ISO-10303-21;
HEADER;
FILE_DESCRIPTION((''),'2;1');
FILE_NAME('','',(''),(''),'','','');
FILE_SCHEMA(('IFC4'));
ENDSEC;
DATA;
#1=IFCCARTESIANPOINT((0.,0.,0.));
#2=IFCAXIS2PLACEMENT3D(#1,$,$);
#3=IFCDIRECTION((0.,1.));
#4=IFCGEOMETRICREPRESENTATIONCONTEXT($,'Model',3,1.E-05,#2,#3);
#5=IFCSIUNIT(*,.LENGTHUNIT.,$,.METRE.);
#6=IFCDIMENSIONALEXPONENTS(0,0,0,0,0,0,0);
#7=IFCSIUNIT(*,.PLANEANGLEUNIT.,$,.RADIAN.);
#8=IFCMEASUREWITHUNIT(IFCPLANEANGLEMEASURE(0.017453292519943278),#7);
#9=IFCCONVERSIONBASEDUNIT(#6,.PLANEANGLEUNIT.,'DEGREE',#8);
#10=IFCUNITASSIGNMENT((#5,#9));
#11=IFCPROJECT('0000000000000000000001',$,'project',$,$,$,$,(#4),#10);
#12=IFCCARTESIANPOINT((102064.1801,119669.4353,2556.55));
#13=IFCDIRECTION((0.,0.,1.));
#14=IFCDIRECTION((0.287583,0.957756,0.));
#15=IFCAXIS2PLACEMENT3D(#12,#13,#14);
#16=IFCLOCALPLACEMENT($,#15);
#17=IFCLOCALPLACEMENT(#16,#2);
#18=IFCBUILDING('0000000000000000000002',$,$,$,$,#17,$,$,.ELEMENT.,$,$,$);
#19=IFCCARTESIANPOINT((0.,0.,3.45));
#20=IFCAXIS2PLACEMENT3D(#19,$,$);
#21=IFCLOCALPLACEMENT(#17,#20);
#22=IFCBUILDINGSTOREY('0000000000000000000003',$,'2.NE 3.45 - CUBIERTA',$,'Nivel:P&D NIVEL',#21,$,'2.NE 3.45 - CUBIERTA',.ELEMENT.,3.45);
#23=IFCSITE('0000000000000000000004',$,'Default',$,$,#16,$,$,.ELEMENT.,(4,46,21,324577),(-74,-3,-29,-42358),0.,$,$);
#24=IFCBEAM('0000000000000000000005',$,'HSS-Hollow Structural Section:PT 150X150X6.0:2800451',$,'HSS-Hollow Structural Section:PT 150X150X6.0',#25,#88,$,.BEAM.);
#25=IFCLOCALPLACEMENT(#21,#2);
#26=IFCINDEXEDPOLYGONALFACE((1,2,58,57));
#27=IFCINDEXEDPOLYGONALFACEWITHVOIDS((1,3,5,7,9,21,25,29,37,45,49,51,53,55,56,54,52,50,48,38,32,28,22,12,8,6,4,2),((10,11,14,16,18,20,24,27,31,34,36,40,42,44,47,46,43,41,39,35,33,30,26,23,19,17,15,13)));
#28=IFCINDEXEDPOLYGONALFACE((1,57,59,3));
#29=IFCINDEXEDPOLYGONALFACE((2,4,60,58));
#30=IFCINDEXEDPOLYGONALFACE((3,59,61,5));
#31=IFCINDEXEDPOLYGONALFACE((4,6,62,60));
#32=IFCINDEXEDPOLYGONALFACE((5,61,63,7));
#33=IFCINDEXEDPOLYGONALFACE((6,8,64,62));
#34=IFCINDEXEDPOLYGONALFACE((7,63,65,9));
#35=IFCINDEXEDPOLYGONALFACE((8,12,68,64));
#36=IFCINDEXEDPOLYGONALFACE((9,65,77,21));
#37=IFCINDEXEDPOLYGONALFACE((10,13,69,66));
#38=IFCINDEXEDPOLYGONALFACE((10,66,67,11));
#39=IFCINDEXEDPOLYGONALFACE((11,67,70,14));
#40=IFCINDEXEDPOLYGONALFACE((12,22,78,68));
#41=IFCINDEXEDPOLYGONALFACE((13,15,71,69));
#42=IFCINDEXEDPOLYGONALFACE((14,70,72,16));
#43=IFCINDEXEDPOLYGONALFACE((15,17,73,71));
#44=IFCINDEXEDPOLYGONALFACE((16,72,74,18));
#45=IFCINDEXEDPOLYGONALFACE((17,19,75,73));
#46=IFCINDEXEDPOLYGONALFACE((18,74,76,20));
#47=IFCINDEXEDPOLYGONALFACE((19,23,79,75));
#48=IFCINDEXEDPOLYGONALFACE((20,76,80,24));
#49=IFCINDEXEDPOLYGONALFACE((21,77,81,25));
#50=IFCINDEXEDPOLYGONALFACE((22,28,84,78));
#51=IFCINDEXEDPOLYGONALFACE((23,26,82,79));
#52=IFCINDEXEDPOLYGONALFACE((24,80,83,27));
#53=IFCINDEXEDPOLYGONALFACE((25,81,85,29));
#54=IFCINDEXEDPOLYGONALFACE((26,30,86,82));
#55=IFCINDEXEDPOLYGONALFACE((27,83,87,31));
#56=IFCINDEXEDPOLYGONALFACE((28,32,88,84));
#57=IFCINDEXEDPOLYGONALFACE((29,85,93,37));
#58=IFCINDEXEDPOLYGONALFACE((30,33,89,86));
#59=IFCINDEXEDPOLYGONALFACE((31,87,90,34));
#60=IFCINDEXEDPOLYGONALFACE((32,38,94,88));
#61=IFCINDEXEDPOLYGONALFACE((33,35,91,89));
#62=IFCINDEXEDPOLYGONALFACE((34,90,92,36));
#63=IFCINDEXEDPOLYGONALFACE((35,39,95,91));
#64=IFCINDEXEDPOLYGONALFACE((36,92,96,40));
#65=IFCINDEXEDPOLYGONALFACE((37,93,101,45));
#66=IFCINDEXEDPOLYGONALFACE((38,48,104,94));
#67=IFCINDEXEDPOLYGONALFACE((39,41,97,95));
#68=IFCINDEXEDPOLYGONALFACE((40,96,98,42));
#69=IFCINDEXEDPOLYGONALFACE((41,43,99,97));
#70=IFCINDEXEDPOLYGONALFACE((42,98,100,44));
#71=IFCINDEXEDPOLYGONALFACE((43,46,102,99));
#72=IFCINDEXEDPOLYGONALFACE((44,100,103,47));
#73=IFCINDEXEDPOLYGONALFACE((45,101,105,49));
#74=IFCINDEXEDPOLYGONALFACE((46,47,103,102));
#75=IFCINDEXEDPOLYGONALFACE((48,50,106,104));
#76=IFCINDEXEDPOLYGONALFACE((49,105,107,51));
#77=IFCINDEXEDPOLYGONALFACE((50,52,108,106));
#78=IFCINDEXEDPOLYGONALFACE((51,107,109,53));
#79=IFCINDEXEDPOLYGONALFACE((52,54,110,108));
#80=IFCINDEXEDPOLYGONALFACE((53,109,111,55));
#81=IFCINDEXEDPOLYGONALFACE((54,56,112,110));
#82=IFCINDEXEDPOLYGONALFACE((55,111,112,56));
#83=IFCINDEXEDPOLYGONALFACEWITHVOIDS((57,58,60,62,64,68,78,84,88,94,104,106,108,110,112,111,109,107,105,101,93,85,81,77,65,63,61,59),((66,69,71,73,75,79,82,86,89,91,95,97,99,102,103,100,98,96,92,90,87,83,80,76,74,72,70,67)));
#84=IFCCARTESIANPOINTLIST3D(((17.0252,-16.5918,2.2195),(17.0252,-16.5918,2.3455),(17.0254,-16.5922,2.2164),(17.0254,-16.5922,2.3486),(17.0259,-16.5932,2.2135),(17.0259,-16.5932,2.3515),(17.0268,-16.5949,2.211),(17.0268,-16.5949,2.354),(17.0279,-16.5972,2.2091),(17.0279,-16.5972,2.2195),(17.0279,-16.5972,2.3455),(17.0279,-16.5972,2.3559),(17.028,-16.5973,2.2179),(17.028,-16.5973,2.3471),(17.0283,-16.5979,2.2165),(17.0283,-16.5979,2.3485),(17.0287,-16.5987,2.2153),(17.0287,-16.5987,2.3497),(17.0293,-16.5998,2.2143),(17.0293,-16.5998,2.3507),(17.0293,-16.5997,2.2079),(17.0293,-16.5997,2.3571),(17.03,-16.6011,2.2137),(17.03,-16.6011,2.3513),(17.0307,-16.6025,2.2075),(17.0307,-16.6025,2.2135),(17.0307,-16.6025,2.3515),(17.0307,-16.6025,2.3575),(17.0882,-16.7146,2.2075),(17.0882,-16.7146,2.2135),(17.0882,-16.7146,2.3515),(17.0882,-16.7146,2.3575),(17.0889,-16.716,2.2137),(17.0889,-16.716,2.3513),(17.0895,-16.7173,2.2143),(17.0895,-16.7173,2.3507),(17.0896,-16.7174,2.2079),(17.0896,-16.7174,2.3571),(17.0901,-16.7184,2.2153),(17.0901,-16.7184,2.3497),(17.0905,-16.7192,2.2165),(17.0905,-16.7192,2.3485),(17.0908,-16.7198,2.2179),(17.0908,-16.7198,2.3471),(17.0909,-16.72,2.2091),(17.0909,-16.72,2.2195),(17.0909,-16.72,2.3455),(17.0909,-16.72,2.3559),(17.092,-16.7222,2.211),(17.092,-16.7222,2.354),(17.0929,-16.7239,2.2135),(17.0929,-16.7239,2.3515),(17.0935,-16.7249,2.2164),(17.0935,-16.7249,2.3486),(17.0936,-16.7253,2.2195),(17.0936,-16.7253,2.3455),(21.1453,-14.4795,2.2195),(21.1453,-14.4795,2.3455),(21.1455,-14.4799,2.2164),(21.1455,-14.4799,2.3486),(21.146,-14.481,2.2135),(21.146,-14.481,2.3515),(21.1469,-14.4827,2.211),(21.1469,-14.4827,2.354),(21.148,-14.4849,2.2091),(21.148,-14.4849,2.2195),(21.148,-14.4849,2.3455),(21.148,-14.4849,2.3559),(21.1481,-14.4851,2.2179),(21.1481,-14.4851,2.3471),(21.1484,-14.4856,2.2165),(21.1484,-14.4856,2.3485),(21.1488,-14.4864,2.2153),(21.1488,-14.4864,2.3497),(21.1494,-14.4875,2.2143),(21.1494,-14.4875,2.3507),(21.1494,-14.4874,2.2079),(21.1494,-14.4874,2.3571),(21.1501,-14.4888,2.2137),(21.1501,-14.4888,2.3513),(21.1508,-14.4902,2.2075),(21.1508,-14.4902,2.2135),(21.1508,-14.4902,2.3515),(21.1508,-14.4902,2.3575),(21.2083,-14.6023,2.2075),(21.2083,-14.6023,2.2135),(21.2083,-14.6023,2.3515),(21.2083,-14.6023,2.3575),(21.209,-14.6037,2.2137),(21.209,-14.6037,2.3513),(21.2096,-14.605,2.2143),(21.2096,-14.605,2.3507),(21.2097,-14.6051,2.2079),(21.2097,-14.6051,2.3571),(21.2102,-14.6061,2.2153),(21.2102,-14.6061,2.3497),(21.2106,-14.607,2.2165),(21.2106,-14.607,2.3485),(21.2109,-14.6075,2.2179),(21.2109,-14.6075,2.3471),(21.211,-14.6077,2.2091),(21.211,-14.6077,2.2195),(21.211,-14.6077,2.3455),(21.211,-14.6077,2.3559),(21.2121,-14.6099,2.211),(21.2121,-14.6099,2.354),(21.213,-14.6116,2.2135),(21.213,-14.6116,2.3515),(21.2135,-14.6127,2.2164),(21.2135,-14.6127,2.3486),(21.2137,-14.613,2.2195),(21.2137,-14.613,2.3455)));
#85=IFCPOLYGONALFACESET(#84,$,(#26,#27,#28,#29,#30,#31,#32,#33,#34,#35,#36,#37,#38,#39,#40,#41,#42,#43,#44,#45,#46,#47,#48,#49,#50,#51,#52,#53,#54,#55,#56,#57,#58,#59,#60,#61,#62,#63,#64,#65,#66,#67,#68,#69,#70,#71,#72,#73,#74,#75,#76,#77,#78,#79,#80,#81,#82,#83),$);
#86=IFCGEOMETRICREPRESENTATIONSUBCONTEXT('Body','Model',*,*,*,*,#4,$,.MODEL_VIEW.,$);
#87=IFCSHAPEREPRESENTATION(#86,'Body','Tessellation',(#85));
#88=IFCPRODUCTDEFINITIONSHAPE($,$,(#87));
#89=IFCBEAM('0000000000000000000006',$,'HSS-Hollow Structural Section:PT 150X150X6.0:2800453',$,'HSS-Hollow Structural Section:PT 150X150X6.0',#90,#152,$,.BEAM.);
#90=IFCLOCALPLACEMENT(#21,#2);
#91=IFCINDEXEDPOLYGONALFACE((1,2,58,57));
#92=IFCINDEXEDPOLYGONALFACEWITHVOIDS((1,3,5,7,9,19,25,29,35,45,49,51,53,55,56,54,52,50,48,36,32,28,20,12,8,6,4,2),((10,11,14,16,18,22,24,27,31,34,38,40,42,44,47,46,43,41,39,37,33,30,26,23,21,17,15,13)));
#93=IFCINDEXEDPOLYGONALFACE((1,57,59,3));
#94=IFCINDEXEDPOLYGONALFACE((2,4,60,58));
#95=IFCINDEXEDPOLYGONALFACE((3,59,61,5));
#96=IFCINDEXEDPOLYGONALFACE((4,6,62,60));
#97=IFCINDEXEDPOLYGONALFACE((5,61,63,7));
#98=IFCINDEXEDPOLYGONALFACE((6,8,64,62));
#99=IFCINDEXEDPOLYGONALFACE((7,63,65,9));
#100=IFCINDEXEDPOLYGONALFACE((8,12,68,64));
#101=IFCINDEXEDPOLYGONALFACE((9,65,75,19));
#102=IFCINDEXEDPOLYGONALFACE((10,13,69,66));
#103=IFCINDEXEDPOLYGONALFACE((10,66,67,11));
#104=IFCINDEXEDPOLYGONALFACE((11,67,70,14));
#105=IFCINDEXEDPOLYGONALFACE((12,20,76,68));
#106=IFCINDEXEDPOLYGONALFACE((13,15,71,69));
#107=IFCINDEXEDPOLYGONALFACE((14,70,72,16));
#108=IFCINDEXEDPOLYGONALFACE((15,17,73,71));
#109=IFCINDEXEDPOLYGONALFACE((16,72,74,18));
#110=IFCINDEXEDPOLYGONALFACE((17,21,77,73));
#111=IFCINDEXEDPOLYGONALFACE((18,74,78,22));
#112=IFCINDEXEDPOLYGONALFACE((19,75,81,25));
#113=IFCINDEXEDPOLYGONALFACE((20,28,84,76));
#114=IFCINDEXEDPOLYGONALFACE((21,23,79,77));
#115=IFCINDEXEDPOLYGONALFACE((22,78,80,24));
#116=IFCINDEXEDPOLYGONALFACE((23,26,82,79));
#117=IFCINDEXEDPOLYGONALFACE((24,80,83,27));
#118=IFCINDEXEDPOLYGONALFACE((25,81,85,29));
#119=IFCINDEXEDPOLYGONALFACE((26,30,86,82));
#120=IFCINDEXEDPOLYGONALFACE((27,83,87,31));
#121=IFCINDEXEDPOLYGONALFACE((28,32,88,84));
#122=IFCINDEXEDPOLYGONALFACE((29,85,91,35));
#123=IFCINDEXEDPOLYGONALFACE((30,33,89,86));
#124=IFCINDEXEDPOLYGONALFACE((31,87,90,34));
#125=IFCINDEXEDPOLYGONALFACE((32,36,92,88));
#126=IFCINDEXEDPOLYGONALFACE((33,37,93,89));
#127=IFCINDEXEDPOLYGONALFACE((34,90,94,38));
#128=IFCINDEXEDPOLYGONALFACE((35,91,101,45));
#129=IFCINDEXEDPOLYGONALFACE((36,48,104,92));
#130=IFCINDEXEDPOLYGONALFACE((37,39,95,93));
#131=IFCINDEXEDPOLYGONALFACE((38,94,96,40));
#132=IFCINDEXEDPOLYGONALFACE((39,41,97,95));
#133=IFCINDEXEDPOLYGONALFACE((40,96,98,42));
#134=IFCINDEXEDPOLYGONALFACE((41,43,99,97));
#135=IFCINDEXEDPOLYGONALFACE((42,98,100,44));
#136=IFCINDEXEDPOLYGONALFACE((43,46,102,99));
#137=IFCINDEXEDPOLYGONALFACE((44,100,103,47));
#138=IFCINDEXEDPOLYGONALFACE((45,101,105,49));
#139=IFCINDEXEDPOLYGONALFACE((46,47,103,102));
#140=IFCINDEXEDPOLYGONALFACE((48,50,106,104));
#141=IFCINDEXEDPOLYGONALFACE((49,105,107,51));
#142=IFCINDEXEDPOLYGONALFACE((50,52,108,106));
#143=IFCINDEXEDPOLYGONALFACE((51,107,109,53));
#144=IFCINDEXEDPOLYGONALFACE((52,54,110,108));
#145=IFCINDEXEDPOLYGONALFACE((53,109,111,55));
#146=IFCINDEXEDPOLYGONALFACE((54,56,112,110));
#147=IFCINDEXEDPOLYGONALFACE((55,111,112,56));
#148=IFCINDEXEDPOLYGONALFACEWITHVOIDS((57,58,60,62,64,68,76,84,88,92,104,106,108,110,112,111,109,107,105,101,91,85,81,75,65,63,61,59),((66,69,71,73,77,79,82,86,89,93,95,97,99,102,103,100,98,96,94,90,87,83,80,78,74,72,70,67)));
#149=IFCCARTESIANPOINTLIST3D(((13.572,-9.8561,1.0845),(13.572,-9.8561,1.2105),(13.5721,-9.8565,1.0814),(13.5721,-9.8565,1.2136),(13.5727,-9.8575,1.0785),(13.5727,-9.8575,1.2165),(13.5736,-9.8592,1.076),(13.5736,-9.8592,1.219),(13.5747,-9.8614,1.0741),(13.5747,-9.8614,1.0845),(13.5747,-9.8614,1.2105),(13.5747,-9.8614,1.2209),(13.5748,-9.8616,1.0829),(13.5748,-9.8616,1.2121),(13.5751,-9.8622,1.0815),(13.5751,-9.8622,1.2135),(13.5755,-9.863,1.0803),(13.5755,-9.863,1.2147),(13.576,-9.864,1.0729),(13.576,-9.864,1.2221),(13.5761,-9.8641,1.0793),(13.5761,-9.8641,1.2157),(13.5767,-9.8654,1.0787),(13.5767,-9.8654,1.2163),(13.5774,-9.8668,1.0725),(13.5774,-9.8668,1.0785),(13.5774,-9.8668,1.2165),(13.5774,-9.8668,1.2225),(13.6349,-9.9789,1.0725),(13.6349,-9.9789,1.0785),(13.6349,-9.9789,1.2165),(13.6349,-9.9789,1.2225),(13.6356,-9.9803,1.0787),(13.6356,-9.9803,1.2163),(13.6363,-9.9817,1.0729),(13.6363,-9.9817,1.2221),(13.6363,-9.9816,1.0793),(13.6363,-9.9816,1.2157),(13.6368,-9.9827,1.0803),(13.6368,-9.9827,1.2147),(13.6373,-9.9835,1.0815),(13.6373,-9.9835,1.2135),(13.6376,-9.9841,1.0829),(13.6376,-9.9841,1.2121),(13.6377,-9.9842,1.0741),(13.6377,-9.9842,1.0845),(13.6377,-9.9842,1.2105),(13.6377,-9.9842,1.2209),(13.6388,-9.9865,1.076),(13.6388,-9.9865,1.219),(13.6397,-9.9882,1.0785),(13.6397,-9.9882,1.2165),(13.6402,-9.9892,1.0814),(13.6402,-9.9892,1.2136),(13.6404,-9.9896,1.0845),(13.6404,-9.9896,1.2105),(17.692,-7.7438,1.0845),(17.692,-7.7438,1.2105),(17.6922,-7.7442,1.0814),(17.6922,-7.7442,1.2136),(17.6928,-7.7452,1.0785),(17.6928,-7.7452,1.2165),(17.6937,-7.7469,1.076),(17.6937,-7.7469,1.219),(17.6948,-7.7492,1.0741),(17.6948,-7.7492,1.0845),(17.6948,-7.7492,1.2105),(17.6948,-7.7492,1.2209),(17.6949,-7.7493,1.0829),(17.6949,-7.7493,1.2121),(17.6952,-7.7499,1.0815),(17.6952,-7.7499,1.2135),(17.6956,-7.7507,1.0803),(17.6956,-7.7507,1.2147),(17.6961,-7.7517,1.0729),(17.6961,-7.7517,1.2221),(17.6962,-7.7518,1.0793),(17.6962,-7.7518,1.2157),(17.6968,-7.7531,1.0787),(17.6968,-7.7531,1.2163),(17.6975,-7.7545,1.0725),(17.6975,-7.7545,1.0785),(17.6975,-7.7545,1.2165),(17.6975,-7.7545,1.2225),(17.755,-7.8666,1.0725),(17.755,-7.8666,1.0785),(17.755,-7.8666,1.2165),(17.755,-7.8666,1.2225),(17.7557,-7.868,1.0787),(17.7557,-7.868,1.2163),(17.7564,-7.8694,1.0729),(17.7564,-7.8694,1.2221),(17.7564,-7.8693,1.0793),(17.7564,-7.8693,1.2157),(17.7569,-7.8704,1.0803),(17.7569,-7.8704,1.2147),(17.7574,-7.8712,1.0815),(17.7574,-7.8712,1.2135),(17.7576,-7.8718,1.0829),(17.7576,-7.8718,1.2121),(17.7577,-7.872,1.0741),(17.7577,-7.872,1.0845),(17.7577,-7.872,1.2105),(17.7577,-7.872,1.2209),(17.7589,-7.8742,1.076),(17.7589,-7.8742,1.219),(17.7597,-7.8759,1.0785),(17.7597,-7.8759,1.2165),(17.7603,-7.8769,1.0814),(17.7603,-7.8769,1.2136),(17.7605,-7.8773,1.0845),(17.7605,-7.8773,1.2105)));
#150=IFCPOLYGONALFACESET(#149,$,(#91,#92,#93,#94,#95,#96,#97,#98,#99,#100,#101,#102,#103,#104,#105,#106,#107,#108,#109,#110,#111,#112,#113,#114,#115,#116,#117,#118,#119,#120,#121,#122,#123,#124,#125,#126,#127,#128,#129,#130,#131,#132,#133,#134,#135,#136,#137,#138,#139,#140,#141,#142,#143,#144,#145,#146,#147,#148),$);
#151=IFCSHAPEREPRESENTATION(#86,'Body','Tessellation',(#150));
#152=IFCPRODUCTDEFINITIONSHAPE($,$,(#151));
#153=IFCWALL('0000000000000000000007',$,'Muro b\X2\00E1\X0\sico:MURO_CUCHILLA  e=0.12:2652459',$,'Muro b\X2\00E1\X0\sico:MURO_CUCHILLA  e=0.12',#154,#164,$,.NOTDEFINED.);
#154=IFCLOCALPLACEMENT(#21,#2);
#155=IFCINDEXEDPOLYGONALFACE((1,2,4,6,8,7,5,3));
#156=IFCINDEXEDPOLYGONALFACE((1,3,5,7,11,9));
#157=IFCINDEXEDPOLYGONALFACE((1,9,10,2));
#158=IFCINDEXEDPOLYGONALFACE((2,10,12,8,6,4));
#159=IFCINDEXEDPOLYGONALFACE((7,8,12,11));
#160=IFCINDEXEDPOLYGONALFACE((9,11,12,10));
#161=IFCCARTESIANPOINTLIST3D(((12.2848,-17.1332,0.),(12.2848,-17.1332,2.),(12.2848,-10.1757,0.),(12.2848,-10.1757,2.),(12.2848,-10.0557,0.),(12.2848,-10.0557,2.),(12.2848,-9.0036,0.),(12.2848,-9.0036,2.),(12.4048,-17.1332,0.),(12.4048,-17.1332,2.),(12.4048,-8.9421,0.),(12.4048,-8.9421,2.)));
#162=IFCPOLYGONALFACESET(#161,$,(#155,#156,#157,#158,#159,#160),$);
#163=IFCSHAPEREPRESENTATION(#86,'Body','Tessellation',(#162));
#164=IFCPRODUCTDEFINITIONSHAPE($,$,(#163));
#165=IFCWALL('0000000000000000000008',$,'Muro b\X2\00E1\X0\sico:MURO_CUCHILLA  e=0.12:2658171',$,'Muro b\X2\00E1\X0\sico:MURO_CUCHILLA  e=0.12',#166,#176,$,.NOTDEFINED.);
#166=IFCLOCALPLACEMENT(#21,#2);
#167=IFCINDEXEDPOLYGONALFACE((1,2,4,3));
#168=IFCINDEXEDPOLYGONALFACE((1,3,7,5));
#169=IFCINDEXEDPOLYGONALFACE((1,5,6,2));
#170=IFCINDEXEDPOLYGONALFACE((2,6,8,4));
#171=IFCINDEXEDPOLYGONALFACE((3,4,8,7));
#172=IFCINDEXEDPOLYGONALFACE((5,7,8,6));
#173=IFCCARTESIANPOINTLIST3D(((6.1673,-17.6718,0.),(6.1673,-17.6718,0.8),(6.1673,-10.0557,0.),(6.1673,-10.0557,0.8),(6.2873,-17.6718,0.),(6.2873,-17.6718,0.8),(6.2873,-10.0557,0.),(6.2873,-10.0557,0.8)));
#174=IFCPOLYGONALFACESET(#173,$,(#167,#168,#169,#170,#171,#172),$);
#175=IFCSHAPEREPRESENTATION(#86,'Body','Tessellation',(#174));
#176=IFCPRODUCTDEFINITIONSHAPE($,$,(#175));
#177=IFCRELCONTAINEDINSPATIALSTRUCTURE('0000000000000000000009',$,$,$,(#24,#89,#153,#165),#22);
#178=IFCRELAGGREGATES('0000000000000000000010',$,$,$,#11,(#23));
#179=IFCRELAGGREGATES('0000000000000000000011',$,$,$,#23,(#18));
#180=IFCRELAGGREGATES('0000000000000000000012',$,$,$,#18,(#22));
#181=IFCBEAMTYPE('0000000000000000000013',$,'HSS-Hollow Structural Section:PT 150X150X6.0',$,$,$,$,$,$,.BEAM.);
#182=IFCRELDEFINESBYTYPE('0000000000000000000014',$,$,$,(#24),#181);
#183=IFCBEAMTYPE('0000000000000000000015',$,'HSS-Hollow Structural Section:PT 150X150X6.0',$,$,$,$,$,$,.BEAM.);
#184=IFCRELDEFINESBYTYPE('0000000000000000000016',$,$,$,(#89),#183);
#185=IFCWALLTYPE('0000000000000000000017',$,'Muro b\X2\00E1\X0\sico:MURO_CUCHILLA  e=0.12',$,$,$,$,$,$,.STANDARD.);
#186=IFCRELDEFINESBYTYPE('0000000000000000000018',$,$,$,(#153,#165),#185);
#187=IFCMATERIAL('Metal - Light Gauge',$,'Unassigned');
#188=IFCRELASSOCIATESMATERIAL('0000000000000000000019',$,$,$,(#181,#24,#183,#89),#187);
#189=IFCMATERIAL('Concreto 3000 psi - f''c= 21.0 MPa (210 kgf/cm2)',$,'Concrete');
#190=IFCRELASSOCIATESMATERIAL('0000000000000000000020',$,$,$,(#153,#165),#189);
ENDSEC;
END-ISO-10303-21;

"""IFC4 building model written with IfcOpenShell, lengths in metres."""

from ifc_helpers import new_model, entity, si_unit, converted_unit, direction, frame, origin, place, context, subcontext, project, spatial, line, arc, indexed_curve, outline, extrude, source, transform, mapped, material, type_object, type_shapes, element, save


model = new_model("IFC4")

# Units and contexts
model_context = context("Model", 3, precision=1e-05, world=origin(), true_north=direction((0.0, 1.0)))
body_context = subcontext(model_context, "Body", "Model", "MODEL_VIEW")
ifc_project = project(units=[si_unit("LENGTHUNIT", "METRE"), converted_unit("PLANEANGLEUNIT", "DEGREE", entity("IfcPlaneAngleMeasure", 0.017453292519943278), si_unit("PLANEANGLEUNIT", "RADIAN"), dimensions=[0, 0, 0, 0, 0, 0, 0])], contexts=[model_context])

# Site, building, storey
site_placement = place(None, frame((102064.1801, 119669.4353, 2556.55), z_axis=(0.0, 0.0, 1.0), x_axis=(0.287583, 0.957756, 0.0)))
site = spatial("IfcSite", under=ifc_project, at=site_placement, Name="Default", CompositionType="ELEMENT", RefLatitude=(4, 46, 21, 324577), RefLongitude=(-74, -3, -29, -42358), RefElevation=0.0)
building_placement = place(site_placement, origin())
building = spatial("IfcBuilding", under=site, at=building_placement, CompositionType="ELEMENT")
storey_placement = place(building_placement, frame((0.0, 0.0, 3.45)))
storey = spatial("IfcBuildingStorey", under=building, at=storey_placement, Name="2.NE 3.45 - CUBIERTA", ObjectType="Nivel:P&D NIVEL", LongName="2.NE 3.45 - CUBIERTA", CompositionType="ELEMENT", Elevation=3.45)

# Beams
ifc_material_1 = material(Name="Metal - Light Gauge", Category="Unassigned")
ifc_material_2 = material(Name="Concreto 3000 psi - f'c= 21.0 MPa (210 kgf/cm2)", Category="Concrete")
beam_type_1 = type_object("IfcBeamType", Name="HSS-Hollow Structural Section:PT 150X150X6.0", PredefinedType="BEAM", material=ifc_material_1)
shared_shape_1 = source(origin(), body_context, "Body", "SweptSolid", [
    extrude(outline(indexed_curve([(-0.063, -0.075), (0.063, -0.075), (0.0715, -0.0715), (0.075, -0.063), (0.075, 0.063), (0.0715, 0.0715), (0.063, 0.075), (-0.063, 0.075), (-0.0715, 0.0715), (-0.075, 0.063), (-0.075, -0.063), (-0.0715, -0.0715)], segments=[line(1, 2), arc(2, 3, 4), line(4, 5), arc(5, 6, 7), line(7, 8), arc(8, 9, 10), line(10, 11), arc(11, 12, 1)], self_intersect=False), holes=[indexed_curve([(-0.069, 0.063), (-0.0672, 0.0672), (-0.063, 0.069), (0.063, 0.069), (0.0672, 0.0672), (0.069, 0.063), (0.069, -0.063), (0.0672, -0.0672), (0.063, -0.069), (-0.063, -0.069), (-0.0672, -0.0672), (-0.069, -0.063)], segments=[arc(1, 2, 3), line(3, 4), arc(4, 5, 6), line(6, 7), arc(7, 8, 9), line(9, 10), arc(10, 11, 12), line(12, 1)], self_intersect=False)]), frame((17.0594, -16.6586, 5.7325), z_axis=(0.889869, 0.456217, 0.0), x_axis=(0.0, 0.0, -1.0)), (0.0, 0.0, 1.0), 4.63),
])
type_shapes(beam_type_1, [shared_shape_1])
beam_1_placement = place(storey_placement, frame((0.0, 0.0, -3.45)))
element("IfcBeam", 1, at=beam_1_placement, inside=storey, type_object=beam_type_1, material=ifc_material_1, Name="HSS-Hollow Structural Section:PT 150X150X6.0:2800451", ObjectType="HSS-Hollow Structural Section:PT 150X150X6.0", PredefinedType="BEAM", context=body_context, shape_type="MappedRepresentation", body=[
    mapped(shared_shape_1, transform((0.0, 0.0, 0.0), scale=1.0)),
])
beam_type_2 = type_object("IfcBeamType", Name="HSS-Hollow Structural Section:PT 150X150X6.0", PredefinedType="BEAM", material=ifc_material_1)
shared_shape_2 = source(origin(), body_context, "Body", "SweptSolid", [
    extrude(outline(indexed_curve([(-0.063, -0.075), (0.063, -0.075), (0.0715, -0.0715), (0.075, -0.063), (0.075, 0.063), (0.0715, 0.0715), (0.063, 0.075), (-0.063, 0.075), (-0.0715, 0.0715), (-0.075, 0.063), (-0.075, -0.063), (-0.0715, -0.0715)], segments=[line(1, 2), arc(2, 3, 4), line(4, 5), arc(5, 6, 7), line(7, 8), arc(8, 9, 10), line(10, 11), arc(11, 12, 1)], self_intersect=False), holes=[indexed_curve([(-0.069, 0.063), (-0.0672, 0.0672), (-0.063, 0.069), (0.063, 0.069), (0.0672, 0.0672), (0.069, 0.063), (0.069, -0.063), (0.0672, -0.0672), (0.063, -0.069), (-0.063, -0.069), (-0.0672, -0.0672), (-0.069, -0.063)], segments=[arc(1, 2, 3), line(3, 4), arc(4, 5, 6), line(6, 7), arc(7, 8, 9), line(9, 10), arc(10, 11, 12), line(12, 1)], self_intersect=False)]), frame((13.6062, -9.9228, 4.5975), z_axis=(0.889869, 0.456217, 0.0), x_axis=(0.0, 0.0, -1.0)), (0.0, 0.0, 1.0), 4.63),
])
type_shapes(beam_type_2, [shared_shape_2])
beam_2_placement = place(storey_placement, frame((0.0, 0.0, -3.45)))
element("IfcBeam", 2, at=beam_2_placement, inside=storey, type_object=beam_type_2, material=ifc_material_1, Name="HSS-Hollow Structural Section:PT 150X150X6.0:2800453", ObjectType="HSS-Hollow Structural Section:PT 150X150X6.0", PredefinedType="BEAM", context=body_context, shape_type="MappedRepresentation", body=[
    mapped(shared_shape_2, transform((0.0, 0.0, 0.0), scale=1.0)),
])

# Walls
wall_type = type_object("IfcWallType", Name="Muro básico:MURO_CUCHILLA  e=0.12", PredefinedType="STANDARD")
wall_1_placement = place(storey_placement, frame((12.3448, -17.1332, 0.0), z_axis=(0.0, 0.0, 1.0), x_axis=(0.0, 1.0, 0.0)))
element("IfcWall", 3, at=wall_1_placement, inside=storey, type_object=wall_type, material=ifc_material_2, Name="Muro básico:MURO_CUCHILLA  e=0.12:2652459", ObjectType="Muro básico:MURO_CUCHILLA  e=0.12", PredefinedType="NOTDEFINED", context=body_context, shape_type="SweptSolid", body=[
    extrude(outline(indexed_curve([(8.1912, -0.06), (8.1297, 0.06), (7.0775, 0.06), (6.9575, 0.06), (0.0, 0.06), (0.0, -0.06), (8.1912, -0.06)], self_intersect=False)), origin(), (0.0, 0.0, 1.0), 2.0),
])
wall_2_placement = place(storey_placement, frame((6.2273, -17.6718, 0.0), z_axis=(0.0, 0.0, 1.0), x_axis=(0.0, 1.0, 0.0)))
element("IfcWall", 4, at=wall_2_placement, inside=storey, type_object=wall_type, material=ifc_material_2, Name="Muro básico:MURO_CUCHILLA  e=0.12:2658171", ObjectType="Muro básico:MURO_CUCHILLA  e=0.12", PredefinedType="NOTDEFINED", context=body_context, shape_type="SweptSolid", body=[
    extrude(outline(indexed_curve([(7.6161, 0.06), (0.0, 0.06), (0.0, -0.06), (7.6161, -0.06), (7.6161, 0.06)], self_intersect=False)), origin(), (0.0, 0.0, 1.0), 0.8),
])

save(model, "model.ifc")
